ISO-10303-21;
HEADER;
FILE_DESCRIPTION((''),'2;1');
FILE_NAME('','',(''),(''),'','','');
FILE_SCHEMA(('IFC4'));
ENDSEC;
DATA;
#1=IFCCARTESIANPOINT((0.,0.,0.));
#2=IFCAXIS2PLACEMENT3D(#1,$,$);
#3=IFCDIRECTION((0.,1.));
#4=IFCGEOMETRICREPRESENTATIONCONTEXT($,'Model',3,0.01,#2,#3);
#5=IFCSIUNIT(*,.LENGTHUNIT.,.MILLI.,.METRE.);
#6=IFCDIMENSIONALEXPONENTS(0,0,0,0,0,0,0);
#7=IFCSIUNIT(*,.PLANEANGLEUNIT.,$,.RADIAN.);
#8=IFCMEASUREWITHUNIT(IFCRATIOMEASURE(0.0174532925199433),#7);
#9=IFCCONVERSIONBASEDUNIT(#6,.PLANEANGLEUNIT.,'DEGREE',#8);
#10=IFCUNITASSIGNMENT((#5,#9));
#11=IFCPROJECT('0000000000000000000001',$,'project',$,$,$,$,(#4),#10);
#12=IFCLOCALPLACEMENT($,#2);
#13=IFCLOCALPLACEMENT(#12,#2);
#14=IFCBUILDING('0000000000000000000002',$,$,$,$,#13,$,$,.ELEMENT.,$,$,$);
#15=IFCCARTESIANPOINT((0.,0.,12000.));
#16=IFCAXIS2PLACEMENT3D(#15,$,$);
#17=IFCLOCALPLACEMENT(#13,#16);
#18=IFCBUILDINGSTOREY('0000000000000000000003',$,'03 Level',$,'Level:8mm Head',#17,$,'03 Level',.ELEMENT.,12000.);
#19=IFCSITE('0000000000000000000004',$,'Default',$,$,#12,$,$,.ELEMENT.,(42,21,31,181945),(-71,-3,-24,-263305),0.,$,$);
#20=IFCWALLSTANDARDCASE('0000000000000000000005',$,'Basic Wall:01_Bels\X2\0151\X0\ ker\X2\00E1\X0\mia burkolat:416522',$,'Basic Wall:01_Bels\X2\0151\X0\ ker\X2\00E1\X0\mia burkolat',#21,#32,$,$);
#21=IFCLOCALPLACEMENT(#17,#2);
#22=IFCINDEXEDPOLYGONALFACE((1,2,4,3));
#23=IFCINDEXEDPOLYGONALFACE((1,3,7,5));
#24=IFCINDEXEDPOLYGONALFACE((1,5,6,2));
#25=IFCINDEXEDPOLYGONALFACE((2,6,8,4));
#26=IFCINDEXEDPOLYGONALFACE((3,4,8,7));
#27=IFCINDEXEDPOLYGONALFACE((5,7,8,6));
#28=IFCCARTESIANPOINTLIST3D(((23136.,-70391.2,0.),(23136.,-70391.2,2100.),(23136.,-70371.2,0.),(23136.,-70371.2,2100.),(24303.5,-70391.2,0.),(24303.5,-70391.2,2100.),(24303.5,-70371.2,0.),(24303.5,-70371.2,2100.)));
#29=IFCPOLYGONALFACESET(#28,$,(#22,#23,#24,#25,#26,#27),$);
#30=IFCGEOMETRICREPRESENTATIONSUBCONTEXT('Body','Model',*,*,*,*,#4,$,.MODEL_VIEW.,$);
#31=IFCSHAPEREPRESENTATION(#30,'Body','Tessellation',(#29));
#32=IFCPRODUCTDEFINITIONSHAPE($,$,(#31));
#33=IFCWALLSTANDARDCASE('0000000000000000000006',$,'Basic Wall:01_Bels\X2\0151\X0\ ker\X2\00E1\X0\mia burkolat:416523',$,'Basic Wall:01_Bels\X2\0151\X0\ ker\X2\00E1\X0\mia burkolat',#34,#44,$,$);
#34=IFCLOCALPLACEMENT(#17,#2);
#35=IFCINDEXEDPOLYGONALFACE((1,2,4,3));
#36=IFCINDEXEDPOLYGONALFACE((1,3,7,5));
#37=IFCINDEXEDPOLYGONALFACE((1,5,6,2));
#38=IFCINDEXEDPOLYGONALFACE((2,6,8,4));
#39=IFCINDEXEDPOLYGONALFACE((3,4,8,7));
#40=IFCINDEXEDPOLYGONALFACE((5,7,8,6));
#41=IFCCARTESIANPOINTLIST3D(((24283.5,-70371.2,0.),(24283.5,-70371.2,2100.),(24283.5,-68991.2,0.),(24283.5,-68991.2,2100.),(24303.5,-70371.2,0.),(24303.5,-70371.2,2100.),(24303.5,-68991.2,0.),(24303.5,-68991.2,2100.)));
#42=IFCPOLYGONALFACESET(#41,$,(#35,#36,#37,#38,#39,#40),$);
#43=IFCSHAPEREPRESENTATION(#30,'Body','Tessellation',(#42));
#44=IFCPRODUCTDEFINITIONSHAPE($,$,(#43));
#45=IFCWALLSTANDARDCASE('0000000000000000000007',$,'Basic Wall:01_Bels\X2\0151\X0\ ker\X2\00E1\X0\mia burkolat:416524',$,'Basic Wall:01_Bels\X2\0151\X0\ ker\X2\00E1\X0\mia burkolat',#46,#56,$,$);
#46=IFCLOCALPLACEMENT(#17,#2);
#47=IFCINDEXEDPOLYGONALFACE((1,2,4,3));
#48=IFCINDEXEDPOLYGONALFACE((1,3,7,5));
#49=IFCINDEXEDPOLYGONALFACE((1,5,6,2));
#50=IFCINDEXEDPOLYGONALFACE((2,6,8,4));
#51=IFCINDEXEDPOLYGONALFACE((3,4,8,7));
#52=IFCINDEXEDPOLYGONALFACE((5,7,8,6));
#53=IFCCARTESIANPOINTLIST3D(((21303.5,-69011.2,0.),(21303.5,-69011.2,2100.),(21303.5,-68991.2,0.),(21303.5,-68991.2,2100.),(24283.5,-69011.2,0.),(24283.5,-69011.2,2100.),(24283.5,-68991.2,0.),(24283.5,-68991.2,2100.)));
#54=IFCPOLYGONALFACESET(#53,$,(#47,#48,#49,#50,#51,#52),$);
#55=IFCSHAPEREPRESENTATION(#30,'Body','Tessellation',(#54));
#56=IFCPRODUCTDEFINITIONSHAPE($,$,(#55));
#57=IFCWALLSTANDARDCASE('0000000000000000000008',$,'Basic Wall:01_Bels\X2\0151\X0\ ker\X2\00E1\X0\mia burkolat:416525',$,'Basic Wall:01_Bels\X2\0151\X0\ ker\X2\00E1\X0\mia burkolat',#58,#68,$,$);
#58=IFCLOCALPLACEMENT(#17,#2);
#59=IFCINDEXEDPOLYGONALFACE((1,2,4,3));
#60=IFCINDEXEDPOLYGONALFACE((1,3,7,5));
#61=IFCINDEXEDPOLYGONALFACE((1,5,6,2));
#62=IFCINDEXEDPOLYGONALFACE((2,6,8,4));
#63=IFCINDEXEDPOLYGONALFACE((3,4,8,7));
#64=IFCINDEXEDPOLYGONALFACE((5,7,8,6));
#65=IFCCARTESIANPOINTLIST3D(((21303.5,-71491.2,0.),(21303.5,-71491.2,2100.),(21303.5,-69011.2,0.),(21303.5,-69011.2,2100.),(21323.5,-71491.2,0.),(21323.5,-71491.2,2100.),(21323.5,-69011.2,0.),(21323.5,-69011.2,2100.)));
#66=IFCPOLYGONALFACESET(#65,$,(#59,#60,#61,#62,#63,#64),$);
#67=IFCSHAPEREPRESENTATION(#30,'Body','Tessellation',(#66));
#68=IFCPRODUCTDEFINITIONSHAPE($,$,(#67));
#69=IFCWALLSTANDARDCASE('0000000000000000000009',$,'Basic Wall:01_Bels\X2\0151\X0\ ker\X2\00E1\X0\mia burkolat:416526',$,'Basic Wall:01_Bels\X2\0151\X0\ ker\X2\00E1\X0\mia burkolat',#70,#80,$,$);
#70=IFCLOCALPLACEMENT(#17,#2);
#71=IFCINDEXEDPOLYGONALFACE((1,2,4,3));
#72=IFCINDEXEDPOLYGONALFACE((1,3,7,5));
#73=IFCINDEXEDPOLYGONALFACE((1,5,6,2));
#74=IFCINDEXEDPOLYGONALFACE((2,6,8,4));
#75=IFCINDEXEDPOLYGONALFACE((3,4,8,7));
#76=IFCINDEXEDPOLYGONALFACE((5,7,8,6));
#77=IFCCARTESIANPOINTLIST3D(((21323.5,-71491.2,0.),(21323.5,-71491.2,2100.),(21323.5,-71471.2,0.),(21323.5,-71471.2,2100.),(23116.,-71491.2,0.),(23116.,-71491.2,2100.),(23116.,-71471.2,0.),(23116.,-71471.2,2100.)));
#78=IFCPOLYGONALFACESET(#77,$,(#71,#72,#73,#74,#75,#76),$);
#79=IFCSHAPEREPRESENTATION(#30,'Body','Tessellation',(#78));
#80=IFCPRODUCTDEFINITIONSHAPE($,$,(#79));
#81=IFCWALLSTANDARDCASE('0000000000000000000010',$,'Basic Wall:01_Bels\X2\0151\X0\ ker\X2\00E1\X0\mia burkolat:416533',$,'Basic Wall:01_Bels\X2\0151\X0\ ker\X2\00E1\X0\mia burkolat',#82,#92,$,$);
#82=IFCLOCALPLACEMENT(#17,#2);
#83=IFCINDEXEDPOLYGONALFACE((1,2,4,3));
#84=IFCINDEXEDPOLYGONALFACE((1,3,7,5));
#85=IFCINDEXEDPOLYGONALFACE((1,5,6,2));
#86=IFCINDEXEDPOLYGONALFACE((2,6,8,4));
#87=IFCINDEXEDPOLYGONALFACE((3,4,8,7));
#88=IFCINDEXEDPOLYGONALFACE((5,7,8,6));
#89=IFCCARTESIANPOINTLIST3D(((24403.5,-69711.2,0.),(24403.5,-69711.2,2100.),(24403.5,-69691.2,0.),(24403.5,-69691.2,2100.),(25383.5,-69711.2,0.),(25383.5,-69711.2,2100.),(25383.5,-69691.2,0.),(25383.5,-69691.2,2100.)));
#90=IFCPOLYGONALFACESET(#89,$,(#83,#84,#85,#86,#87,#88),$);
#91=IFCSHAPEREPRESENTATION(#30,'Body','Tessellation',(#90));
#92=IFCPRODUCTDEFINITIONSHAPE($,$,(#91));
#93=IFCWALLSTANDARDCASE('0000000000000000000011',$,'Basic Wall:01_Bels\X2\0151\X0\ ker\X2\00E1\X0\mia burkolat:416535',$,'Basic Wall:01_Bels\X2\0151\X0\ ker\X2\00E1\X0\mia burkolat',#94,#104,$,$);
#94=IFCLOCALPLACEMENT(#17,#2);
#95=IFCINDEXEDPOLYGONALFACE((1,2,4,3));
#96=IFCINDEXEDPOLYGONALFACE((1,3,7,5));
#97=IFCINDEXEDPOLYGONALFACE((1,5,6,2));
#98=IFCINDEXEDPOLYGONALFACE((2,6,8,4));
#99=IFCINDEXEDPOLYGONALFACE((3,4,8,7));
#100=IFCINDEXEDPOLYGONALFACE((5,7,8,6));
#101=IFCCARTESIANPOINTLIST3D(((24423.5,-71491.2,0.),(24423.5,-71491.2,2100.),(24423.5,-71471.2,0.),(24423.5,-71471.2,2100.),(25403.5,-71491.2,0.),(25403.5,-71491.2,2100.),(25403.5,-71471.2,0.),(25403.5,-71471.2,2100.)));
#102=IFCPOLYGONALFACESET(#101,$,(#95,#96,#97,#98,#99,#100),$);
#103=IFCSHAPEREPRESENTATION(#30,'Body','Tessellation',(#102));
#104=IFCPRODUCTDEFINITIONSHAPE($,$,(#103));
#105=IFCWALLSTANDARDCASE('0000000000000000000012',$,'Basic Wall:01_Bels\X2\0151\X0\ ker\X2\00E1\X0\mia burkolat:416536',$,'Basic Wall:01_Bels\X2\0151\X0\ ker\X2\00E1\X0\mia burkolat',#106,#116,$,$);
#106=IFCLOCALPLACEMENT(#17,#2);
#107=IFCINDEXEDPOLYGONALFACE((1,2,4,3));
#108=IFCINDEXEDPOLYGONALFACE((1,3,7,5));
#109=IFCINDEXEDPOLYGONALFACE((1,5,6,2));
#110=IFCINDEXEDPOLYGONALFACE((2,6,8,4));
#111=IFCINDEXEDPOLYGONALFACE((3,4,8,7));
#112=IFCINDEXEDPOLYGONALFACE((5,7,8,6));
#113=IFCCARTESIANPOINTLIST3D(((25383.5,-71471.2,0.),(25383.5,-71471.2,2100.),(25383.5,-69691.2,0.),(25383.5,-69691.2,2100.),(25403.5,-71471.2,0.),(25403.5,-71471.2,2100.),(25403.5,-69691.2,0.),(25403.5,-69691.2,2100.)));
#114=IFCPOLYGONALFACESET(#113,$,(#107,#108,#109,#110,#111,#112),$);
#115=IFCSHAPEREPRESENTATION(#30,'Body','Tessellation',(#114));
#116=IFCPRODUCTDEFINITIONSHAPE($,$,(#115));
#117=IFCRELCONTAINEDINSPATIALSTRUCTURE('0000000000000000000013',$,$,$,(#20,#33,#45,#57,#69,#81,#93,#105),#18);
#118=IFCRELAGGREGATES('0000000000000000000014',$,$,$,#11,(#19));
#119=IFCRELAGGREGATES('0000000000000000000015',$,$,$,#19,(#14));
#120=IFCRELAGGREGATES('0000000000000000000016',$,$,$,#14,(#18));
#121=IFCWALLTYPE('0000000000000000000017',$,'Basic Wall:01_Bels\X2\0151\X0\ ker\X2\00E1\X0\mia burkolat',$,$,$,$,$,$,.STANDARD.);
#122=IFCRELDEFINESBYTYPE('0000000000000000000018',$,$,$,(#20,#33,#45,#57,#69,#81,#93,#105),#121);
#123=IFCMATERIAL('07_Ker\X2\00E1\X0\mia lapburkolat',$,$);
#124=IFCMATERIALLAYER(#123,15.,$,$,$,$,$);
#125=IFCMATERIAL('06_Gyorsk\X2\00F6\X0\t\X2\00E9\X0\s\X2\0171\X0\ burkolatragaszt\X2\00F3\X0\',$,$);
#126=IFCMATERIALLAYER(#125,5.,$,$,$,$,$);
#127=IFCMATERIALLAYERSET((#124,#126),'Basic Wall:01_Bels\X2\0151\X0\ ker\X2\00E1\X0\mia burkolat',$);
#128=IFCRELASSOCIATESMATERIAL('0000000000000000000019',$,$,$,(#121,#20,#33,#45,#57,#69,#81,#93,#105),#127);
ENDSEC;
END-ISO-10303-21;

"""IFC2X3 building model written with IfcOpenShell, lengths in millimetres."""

from ifc_helpers import new_model, entity, si_unit, converted_unit, direction, frame, frame_2d, origin, place, context, subcontext, project, spatial, rectangle, extrude, material, layer, layer_set, layer_usage, type_object, element, save


model = new_model("IFC2X3")

# Units and contexts
model_context = context("Model", 3, precision=0.01, world=origin(), true_north=direction((0.0, 1.0)))
body_context = subcontext(model_context, "Body", "Model", "MODEL_VIEW")
ifc_project = project(units=[si_unit("LENGTHUNIT", "METRE", prefix="MILLI"), converted_unit("PLANEANGLEUNIT", "DEGREE", entity("IfcRatioMeasure", 0.0174532925199433), si_unit("PLANEANGLEUNIT", "RADIAN"), dimensions=[0, 0, 0, 0, 0, 0, 0])], contexts=[model_context])

# Site, building, storey
site_placement = place(None, origin())
site = spatial("IfcSite", under=ifc_project, at=site_placement, Name="Default", CompositionType="ELEMENT", RefLatitude=(42, 21, 31, 181945), RefLongitude=(-71, -3, -24, -263305), RefElevation=0.0)
building_placement = place(site_placement, origin())
building = spatial("IfcBuilding", under=site, at=building_placement, CompositionType="ELEMENT")
storey_placement = place(building_placement, frame((0.0, 0.0, 12000.0)))
storey = spatial("IfcBuildingStorey", under=building, at=storey_placement, Name="03 Level", ObjectType="Level:8mm Head", LongName="03 Level", CompositionType="ELEMENT", Elevation=12000.0)

# Shared definitions
ifc_material_1 = material(Name="07_Kerámia lapburkolat")
ifc_layer_1 = layer(ifc_material_1, 15.0)
ifc_material_2 = material(Name="06_Gyorskötésű burkolatragasztó")
ifc_layer_2 = layer(ifc_material_2, 5.0)
ifc_layer_set_1 = layer_set([ifc_layer_1, ifc_layer_2], Name="Basic Wall:01_Belső kerámia burkolat")
wall_type_1 = type_object("IfcWallType", Name="Basic Wall:01_Belső kerámia burkolat", PredefinedType="STANDARD", material=ifc_layer_set_1)

# Walls
ifc_layer_usage_1 = layer_usage(ifc_layer_set_1, "AXIS2", "NEGATIVE", 10.0)
wall_1_placement = place(storey_placement, frame((23136.0, -70381.2, 0.0)))
element("IfcWallStandardCase", 1, at=wall_1_placement, inside=storey, type_object=wall_type_1, material=ifc_layer_usage_1, Name="Basic Wall:01_Belső kerámia burkolat:416522", ObjectType="Basic Wall:01_Belső kerámia burkolat", context=body_context, shape_type="SweptSolid", body=[
    extrude(rectangle(XDim=1167.5, YDim=20.0, at=frame_2d((583.7, 0.0), x_axis=(-1.0, 0.0))), origin(), (0.0, 0.0, 1.0), 2100.0),
])
ifc_layer_usage_2 = layer_usage(ifc_layer_set_1, "AXIS2", "NEGATIVE", 10.0)
wall_2_placement = place(storey_placement, frame((24293.5, -70371.2, 0.0), z_axis=(0.0, 0.0, 1.0), x_axis=(0.0, 1.0, 0.0)))
element("IfcWallStandardCase", 2, at=wall_2_placement, inside=storey, type_object=wall_type_1, material=ifc_layer_usage_2, Name="Basic Wall:01_Belső kerámia burkolat:416523", ObjectType="Basic Wall:01_Belső kerámia burkolat", context=body_context, shape_type="SweptSolid", body=[
    extrude(rectangle(XDim=1380.0, YDim=20.0, at=frame_2d((690.0, 0.0), x_axis=(-1.0, 0.0))), origin(), (0.0, 0.0, 1.0), 2100.0),
])
ifc_layer_usage_3 = layer_usage(ifc_layer_set_1, "AXIS2", "NEGATIVE", 10.0)
wall_3_placement = place(storey_placement, frame((24283.5, -69001.2, 0.0), z_axis=(0.0, 0.0, 1.0), x_axis=(-1.0, 0.0, 0.0)))
element("IfcWallStandardCase", 3, at=wall_3_placement, inside=storey, type_object=wall_type_1, material=ifc_layer_usage_3, Name="Basic Wall:01_Belső kerámia burkolat:416524", ObjectType="Basic Wall:01_Belső kerámia burkolat", context=body_context, shape_type="SweptSolid", body=[
    extrude(rectangle(XDim=2980.0, YDim=20.0, at=frame_2d((1490.0, 0.0), x_axis=(-1.0, 0.0))), origin(), (0.0, 0.0, 1.0), 2100.0),
])
ifc_layer_usage_4 = layer_usage(ifc_layer_set_1, "AXIS2", "NEGATIVE", 10.0)
wall_4_placement = place(storey_placement, frame((21313.5, -69011.2, 0.0), z_axis=(0.0, 0.0, 1.0), x_axis=(0.0, -1.0, 0.0)))
element("IfcWallStandardCase", 4, at=wall_4_placement, inside=storey, type_object=wall_type_1, material=ifc_layer_usage_4, Name="Basic Wall:01_Belső kerámia burkolat:416525", ObjectType="Basic Wall:01_Belső kerámia burkolat", context=body_context, shape_type="SweptSolid", body=[
    extrude(rectangle(XDim=2480.0, YDim=20.0, at=frame_2d((1240.0, 0.0), x_axis=(-1.0, 0.0))), origin(), (0.0, 0.0, 1.0), 2100.0),
])
ifc_layer_usage_5 = layer_usage(ifc_layer_set_1, "AXIS2", "NEGATIVE", 10.0)
wall_5_placement = place(storey_placement, frame((21323.5, -71481.2, 0.0)))
element("IfcWallStandardCase", 5, at=wall_5_placement, inside=storey, type_object=wall_type_1, material=ifc_layer_usage_5, Name="Basic Wall:01_Belső kerámia burkolat:416526", ObjectType="Basic Wall:01_Belső kerámia burkolat", context=body_context, shape_type="SweptSolid", body=[
    extrude(rectangle(XDim=1792.5, YDim=20.0, at=frame_2d((896.3, 0.0), x_axis=(-1.0, 0.0))), origin(), (0.0, 0.0, 1.0), 2100.0),
])
ifc_layer_usage_6 = layer_usage(ifc_layer_set_1, "AXIS2", "POSITIVE", -10.0)
wall_6_placement = place(storey_placement, frame((24403.5, -69701.2, 0.0)))
element("IfcWallStandardCase", 6, at=wall_6_placement, inside=storey, type_object=wall_type_1, material=ifc_layer_usage_6, Name="Basic Wall:01_Belső kerámia burkolat:416533", ObjectType="Basic Wall:01_Belső kerámia burkolat", context=body_context, shape_type="SweptSolid", body=[
    extrude(rectangle(XDim=980.0, YDim=20.0, at=frame_2d((490.0, 0.0), x_axis=(-1.0, 0.0))), origin(), (0.0, 0.0, 1.0), 2100.0),
])

# Walls
ifc_layer_usage_7 = layer_usage(ifc_layer_set_1, "AXIS2", "POSITIVE", -10.0)
wall_7_placement = place(storey_placement, frame((25403.5, -71481.2, 0.0), z_axis=(0.0, 0.0, 1.0), x_axis=(-1.0, 0.0, 0.0)))
element("IfcWallStandardCase", 7, at=wall_7_placement, inside=storey, type_object=wall_type_1, material=ifc_layer_usage_7, Name="Basic Wall:01_Belső kerámia burkolat:416535", ObjectType="Basic Wall:01_Belső kerámia burkolat", context=body_context, shape_type="SweptSolid", body=[
    extrude(rectangle(XDim=980.0, YDim=20.0, at=frame_2d((490.0, 0.0), x_axis=(-1.0, 0.0))), origin(), (0.0, 0.0, 1.0), 2100.0),
])
ifc_layer_usage_8 = layer_usage(ifc_layer_set_1, "AXIS2", "POSITIVE", -10.0)
wall_8_placement = place(storey_placement, frame((25393.5, -69691.2, 0.0), z_axis=(0.0, 0.0, 1.0), x_axis=(0.0, -1.0, 0.0)))
element("IfcWallStandardCase", 8, at=wall_8_placement, inside=storey, type_object=wall_type_1, material=ifc_layer_usage_8, Name="Basic Wall:01_Belső kerámia burkolat:416536", ObjectType="Basic Wall:01_Belső kerámia burkolat", context=body_context, shape_type="SweptSolid", body=[
    extrude(rectangle(XDim=1780.0, YDim=20.0, at=frame_2d((890.0, 0.0), x_axis=(-1.0, 0.0))), origin(), (0.0, 0.0, 1.0), 2100.0),
])

save(model, "model.ifc")
